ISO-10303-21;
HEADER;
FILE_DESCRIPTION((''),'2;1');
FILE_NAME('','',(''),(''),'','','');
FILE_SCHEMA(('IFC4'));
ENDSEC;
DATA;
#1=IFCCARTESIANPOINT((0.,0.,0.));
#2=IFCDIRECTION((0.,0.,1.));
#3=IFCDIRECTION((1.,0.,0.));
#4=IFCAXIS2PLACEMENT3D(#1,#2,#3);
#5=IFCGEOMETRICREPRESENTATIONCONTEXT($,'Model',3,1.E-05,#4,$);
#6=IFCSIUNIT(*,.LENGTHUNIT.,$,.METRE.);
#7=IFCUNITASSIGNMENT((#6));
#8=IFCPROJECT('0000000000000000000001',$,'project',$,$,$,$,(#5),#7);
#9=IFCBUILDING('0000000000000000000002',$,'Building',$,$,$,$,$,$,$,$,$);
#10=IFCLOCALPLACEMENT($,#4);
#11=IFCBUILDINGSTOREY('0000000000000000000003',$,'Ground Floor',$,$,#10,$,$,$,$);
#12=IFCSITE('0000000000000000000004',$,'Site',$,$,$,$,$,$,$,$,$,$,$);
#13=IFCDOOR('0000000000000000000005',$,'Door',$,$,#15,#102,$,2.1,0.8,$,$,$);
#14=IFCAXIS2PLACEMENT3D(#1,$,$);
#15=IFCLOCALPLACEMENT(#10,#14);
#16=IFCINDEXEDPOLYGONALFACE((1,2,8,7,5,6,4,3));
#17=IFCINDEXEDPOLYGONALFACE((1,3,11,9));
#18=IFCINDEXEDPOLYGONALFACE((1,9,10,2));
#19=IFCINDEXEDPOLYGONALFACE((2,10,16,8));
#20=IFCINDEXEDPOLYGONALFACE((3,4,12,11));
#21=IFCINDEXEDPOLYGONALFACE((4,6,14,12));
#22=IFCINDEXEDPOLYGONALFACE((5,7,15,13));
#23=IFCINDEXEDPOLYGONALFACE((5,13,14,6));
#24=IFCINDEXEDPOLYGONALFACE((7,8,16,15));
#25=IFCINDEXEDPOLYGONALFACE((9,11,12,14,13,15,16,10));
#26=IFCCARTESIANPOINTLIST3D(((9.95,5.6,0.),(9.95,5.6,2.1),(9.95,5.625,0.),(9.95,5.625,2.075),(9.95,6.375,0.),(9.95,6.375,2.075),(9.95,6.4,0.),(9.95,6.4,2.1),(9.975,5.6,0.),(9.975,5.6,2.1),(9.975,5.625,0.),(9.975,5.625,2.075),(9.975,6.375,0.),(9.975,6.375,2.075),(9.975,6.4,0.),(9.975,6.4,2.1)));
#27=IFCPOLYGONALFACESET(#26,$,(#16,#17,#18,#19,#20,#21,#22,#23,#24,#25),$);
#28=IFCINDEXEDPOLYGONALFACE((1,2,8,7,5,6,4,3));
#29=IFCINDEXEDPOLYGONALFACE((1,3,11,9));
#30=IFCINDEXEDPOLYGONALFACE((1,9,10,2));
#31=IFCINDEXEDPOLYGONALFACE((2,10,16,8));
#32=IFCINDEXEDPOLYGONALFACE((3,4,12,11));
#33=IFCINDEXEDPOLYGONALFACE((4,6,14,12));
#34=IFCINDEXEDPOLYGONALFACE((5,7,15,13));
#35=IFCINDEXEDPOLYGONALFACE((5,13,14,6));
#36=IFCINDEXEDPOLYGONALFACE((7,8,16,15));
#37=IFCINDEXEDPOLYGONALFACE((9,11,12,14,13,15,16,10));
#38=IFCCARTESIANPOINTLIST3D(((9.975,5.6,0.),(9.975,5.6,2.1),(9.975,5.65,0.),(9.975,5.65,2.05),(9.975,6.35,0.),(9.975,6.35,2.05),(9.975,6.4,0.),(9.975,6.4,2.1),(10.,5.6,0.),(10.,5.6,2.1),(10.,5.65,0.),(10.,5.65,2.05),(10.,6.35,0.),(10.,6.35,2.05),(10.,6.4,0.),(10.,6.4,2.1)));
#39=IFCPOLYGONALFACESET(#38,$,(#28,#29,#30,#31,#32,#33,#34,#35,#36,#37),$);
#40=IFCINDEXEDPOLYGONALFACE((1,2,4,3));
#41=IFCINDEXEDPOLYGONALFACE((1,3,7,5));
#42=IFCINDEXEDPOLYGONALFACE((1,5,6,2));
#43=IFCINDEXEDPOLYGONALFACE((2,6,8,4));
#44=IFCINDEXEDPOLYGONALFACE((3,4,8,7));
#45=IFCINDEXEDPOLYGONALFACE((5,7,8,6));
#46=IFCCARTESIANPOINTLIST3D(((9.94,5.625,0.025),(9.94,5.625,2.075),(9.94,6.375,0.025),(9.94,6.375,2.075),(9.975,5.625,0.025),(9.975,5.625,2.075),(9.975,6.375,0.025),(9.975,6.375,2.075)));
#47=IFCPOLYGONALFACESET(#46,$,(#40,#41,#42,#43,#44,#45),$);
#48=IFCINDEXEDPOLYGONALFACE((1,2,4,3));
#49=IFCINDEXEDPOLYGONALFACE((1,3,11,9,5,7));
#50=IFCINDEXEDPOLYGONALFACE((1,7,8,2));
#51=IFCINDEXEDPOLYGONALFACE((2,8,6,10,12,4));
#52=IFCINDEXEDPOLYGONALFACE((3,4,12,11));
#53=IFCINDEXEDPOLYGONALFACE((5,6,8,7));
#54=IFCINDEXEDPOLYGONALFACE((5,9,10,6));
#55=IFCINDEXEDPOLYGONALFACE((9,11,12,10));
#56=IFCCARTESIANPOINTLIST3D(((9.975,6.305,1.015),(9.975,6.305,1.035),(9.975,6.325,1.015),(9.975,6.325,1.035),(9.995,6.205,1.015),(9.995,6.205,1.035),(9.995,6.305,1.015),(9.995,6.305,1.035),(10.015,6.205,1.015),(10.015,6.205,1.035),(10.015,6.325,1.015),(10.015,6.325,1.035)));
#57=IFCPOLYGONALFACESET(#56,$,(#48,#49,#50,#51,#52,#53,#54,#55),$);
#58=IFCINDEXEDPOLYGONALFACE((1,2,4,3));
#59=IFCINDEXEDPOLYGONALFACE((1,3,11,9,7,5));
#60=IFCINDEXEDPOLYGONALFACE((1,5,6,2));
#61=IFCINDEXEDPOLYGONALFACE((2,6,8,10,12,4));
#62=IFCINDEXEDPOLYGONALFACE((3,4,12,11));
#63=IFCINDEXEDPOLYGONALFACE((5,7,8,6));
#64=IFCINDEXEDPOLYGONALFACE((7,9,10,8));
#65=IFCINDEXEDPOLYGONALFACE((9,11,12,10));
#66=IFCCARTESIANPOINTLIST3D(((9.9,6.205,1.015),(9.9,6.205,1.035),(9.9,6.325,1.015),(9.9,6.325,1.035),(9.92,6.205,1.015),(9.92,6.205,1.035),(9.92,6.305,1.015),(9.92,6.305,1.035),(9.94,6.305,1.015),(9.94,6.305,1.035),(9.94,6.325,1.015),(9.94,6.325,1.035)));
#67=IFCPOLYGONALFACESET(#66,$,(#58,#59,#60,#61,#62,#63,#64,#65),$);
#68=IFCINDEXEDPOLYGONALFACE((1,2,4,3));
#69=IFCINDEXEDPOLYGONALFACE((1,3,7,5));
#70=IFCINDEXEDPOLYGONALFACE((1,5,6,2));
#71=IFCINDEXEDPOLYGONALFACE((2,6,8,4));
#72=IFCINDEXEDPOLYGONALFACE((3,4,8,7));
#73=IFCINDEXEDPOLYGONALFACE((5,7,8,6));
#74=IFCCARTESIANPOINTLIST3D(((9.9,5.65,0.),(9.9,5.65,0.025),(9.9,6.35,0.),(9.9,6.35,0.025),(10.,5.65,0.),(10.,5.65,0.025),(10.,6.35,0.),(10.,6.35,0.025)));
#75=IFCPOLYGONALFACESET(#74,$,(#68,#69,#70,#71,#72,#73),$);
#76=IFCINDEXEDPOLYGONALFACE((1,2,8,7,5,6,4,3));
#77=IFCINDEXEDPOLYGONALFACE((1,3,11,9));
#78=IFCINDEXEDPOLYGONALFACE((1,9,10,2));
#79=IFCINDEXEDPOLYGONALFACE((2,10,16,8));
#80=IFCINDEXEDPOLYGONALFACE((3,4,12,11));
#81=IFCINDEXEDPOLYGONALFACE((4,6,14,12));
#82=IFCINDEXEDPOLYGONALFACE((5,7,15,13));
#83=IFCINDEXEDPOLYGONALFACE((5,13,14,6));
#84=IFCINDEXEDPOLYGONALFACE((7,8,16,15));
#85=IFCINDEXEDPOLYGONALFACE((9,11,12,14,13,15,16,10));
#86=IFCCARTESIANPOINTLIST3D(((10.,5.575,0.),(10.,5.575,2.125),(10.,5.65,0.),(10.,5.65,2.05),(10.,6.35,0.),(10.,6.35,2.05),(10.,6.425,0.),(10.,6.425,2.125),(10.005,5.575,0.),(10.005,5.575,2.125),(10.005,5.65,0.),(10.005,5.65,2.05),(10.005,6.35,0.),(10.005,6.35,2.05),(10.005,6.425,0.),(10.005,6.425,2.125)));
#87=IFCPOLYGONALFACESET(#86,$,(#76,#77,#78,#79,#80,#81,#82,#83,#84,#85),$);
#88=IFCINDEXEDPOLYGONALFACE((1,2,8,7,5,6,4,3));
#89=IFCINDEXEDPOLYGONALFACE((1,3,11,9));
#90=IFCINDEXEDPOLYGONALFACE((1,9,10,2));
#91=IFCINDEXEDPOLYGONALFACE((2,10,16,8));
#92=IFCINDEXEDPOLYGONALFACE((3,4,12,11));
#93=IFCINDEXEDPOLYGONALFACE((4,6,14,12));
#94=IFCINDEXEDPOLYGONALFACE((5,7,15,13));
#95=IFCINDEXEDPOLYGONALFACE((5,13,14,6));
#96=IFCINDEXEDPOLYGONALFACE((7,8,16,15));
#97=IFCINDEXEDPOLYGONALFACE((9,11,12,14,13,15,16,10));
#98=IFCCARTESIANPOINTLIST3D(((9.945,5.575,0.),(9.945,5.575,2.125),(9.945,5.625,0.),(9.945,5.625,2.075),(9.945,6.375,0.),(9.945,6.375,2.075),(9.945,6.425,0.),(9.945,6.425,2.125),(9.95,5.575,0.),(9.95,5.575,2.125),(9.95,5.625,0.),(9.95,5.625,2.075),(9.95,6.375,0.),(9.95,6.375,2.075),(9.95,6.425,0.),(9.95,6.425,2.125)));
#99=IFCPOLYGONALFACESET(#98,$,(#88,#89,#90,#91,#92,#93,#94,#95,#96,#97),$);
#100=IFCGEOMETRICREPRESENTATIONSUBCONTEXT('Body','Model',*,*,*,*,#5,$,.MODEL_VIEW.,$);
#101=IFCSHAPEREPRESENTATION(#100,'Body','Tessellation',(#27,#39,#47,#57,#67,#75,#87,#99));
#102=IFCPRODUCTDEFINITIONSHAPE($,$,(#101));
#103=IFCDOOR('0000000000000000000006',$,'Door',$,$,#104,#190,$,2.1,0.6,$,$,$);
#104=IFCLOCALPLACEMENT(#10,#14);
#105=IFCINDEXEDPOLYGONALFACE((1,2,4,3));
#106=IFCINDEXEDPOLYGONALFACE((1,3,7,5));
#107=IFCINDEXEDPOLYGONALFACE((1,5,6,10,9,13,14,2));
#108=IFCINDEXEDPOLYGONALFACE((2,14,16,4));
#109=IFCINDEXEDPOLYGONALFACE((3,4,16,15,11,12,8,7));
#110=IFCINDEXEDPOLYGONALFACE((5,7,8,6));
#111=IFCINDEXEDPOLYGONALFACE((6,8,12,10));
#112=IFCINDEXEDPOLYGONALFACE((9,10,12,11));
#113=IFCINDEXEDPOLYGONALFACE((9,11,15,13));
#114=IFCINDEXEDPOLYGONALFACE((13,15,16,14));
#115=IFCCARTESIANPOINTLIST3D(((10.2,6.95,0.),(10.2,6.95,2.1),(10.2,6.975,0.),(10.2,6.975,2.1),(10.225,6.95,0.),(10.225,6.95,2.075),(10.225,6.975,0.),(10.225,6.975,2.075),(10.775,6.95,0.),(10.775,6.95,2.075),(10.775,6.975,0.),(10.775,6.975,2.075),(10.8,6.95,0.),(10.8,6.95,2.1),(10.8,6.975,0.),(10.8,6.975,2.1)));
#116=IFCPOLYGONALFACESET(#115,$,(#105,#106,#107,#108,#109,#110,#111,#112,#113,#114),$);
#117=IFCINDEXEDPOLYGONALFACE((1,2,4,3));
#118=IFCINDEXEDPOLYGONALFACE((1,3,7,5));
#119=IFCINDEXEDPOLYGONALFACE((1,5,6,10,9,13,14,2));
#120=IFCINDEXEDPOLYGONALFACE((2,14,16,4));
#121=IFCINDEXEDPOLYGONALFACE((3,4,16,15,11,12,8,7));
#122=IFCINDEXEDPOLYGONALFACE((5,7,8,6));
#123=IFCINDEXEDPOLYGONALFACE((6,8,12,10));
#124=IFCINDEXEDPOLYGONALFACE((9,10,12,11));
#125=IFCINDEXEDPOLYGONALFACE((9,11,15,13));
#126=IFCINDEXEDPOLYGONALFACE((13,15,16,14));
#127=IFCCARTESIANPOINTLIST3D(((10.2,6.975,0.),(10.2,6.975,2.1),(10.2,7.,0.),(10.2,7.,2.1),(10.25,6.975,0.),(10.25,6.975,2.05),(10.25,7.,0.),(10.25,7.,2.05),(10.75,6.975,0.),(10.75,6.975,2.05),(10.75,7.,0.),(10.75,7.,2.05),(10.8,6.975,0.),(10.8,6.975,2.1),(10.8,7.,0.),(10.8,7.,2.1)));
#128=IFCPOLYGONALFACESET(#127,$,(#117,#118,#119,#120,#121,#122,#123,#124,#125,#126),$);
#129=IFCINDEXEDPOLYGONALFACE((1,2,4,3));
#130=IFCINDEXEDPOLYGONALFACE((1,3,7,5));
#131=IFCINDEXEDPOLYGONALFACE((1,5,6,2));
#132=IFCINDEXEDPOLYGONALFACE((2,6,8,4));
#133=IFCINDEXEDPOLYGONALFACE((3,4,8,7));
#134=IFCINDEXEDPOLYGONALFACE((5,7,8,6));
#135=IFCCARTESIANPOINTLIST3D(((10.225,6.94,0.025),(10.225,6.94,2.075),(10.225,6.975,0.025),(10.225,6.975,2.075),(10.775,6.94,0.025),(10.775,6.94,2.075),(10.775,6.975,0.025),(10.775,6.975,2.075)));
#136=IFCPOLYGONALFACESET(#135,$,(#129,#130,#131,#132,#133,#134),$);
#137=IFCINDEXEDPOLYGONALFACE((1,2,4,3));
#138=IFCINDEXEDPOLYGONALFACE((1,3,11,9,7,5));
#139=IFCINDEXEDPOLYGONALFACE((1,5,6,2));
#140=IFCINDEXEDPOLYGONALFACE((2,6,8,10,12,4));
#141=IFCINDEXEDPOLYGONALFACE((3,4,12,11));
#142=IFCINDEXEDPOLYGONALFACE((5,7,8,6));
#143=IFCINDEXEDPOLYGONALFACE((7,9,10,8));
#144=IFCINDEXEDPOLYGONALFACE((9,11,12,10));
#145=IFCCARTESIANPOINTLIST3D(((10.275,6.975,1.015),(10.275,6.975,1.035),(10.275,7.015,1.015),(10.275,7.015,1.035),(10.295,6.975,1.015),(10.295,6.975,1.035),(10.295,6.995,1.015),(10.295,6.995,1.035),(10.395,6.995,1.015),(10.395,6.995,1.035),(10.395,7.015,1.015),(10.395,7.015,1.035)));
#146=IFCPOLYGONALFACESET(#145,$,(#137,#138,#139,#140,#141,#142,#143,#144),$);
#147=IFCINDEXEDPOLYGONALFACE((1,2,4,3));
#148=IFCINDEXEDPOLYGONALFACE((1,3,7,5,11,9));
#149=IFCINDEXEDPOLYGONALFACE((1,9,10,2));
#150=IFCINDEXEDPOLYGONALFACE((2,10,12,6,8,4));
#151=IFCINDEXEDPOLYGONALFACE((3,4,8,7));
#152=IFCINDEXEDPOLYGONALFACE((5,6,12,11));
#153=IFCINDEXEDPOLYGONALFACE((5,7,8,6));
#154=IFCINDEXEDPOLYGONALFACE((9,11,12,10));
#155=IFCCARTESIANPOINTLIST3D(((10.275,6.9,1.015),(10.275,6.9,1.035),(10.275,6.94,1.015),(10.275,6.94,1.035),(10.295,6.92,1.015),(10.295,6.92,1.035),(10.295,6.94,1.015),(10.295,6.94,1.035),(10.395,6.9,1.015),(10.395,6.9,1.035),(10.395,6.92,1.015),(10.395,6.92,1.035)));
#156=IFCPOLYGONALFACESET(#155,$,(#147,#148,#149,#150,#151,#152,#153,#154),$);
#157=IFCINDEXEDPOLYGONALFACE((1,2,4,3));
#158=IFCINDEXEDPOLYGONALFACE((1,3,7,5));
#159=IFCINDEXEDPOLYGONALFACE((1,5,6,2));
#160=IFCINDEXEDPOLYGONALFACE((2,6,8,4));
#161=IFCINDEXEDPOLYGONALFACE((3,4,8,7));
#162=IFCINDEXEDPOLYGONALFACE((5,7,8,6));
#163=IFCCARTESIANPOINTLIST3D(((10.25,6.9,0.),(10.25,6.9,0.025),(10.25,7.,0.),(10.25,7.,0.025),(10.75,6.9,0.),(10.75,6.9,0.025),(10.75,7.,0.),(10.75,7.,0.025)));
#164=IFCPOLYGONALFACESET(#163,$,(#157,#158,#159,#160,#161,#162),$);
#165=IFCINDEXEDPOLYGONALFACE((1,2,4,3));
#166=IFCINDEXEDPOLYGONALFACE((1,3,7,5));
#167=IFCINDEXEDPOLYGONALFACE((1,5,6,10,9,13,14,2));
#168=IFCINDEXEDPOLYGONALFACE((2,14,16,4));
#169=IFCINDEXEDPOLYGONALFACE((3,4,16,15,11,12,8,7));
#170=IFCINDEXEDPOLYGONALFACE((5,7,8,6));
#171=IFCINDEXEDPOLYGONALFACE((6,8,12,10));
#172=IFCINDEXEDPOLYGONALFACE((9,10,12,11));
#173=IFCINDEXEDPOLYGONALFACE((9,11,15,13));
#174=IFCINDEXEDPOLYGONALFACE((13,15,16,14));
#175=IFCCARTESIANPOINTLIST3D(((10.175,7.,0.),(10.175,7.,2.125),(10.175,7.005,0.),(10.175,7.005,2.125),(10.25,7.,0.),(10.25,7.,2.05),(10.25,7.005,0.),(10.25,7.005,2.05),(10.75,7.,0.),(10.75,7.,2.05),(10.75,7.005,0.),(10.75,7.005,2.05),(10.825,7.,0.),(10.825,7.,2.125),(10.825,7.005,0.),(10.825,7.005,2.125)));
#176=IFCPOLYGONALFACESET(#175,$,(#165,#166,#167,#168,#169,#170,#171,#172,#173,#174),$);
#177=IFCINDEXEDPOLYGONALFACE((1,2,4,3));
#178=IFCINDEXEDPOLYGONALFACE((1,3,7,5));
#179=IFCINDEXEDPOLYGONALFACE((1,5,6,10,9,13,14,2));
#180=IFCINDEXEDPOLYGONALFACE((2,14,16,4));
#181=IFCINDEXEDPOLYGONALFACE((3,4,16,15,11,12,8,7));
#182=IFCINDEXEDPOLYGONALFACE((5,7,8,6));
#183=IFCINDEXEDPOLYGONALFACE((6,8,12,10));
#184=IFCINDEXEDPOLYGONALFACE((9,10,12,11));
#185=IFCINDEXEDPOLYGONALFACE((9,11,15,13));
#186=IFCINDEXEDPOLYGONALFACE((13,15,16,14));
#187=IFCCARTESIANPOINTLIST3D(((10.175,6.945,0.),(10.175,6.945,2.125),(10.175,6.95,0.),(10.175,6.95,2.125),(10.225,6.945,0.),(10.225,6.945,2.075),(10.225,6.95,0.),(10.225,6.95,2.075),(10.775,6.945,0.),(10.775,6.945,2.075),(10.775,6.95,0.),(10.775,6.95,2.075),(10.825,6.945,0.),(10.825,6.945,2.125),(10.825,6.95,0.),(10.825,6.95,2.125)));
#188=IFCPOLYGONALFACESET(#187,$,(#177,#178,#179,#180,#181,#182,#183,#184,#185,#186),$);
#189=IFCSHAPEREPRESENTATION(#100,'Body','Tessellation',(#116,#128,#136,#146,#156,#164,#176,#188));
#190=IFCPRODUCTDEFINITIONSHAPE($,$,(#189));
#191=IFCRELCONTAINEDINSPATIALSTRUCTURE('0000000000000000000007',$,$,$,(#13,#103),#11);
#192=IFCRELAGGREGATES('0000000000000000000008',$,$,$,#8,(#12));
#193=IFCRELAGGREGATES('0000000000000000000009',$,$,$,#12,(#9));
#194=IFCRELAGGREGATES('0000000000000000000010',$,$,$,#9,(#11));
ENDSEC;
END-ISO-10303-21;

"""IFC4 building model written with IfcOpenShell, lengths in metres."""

from ifc_helpers import new_model, si_unit, frame, origin_with_axes, place, context, subcontext, project, spatial, line, indexed_curve, outline, extrude, element, save


model = new_model("IFC4")

# Units and contexts
model_context = context("Model", 3, precision=1e-05, world=origin_with_axes())
body_context = subcontext(model_context, "Body", "Model", "MODEL_VIEW")
ifc_project = project(units=[si_unit("LENGTHUNIT", "METRE")], contexts=[model_context])

# Site, building, storey
site = spatial("IfcSite", under=ifc_project, Name="Site")
building = spatial("IfcBuilding", under=site, Name="Building")
storey_placement = place(None, origin_with_axes())
storey = spatial("IfcBuildingStorey", under=building, at=storey_placement, Name="Ground Floor")

# Doors
door_1_placement = place(storey_placement, frame((10.0, 5.6, 0.0), z_axis=(0.0, 0.0, 1.0), x_axis=(0.0, 1.0, 0.0)))
element("IfcDoor", 1, at=door_1_placement, inside=storey, Name="Door", OverallHeight=2.1, OverallWidth=0.8, context=body_context, shape_type="SweptSolid", body=[
    extrude(outline(indexed_curve([(0.0, 0.0), (0.0, 2.1), (0.8, 2.1), (0.8, 0.0), (0.775, 0.0), (0.775, 2.075), (0.025, 2.075), (0.025, 0.0)], segments=[line(1, 2, 3, 4, 5, 6, 7, 8, 1)])), frame((0.0, 0.025, 0.0), z_axis=(0.0, -1.0, 0.0), x_axis=(1.0, 0.0, 0.0)), (0.0, 0.0, -1.0), 0.025),
    extrude(outline(indexed_curve([(0.0, 0.0), (0.0, 2.1), (0.8, 2.1), (0.8, 0.0), (0.75, 0.0), (0.75, 2.05), (0.05, 2.05), (0.05, 0.0)], segments=[line(1, 2, 3, 4, 5, 6, 7, 8, 1)])), frame((0.0, 0.0, 0.0), z_axis=(0.0, -1.0, 0.0), x_axis=(1.0, 0.0, 0.0)), (0.0, 0.0, -1.0), 0.025),
    extrude(outline(indexed_curve([(0.0, 0.0), (0.75, 0.0), (0.75, 0.035), (0.0, 0.035)], segments=[line(1, 2, 3, 4, 1)])), frame((0.025, 0.025, 0.025), z_axis=(0.0, 0.0, 1.0), x_axis=(1.0, 0.0, 0.0)), (0.0, 0.0, 1.0), 2.05),
    extrude(outline(indexed_curve([(0.0, 0.0), (0.0, -0.04), (-0.12, -0.04), (-0.12, -0.02), (-0.02, -0.02), (-0.02, 0.0)], segments=[line(1, 2, 3, 4, 5, 6, 1)])), frame((0.725, 0.025, 1.015), z_axis=(0.0, 0.0, 1.0), x_axis=(1.0, 0.0, 0.0)), (0.0, 0.0, 1.0), 0.02),
    extrude(outline(indexed_curve([(0.0, 0.0), (0.0, 0.04), (-0.12, 0.04), (-0.12, 0.02), (-0.02, 0.02), (-0.02, 0.0)], segments=[line(1, 2, 3, 4, 5, 6, 1)])), frame((0.725, 0.06, 1.015), z_axis=(0.0, 0.0, 1.0), x_axis=(1.0, 0.0, 0.0)), (0.0, 0.0, 1.0), 0.02),
    extrude(outline(indexed_curve([(0.0, 0.0), (0.7, 0.0), (0.7, 0.1), (0.0, 0.1)], segments=[line(1, 2, 3, 4, 1)])), frame((0.05, 0.0, 0.0), z_axis=(0.0, 0.0, 1.0), x_axis=(1.0, 0.0, 0.0)), (0.0, 0.0, 1.0), 0.025),
    extrude(outline(indexed_curve([(0.0, 0.0), (0.0, 2.125), (0.85, 2.125), (0.85, 0.0), (0.775, 0.0), (0.775, 2.05), (0.075, 2.05), (0.075, 0.0)], segments=[line(1, 2, 3, 4, 5, 6, 7, 8, 1)])), frame((-0.025, -0.005, 0.0), z_axis=(0.0, -1.0, 0.0), x_axis=(1.0, 0.0, 0.0)), (0.0, 0.0, -1.0), 0.005),
    extrude(outline(indexed_curve([(0.0, 0.0), (0.0, 2.125), (0.85, 2.125), (0.85, 0.0), (0.8, 0.0), (0.8, 2.075), (0.05, 2.075), (0.05, 0.0)], segments=[line(1, 2, 3, 4, 5, 6, 7, 8, 1)])), frame((-0.025, 0.05, 0.0), z_axis=(0.0, -1.0, 0.0), x_axis=(1.0, 0.0, 0.0)), (0.0, 0.0, -1.0), 0.005),
])
door_2_placement = place(storey_placement, frame((10.8, 7.0, 0.0), z_axis=(0.0, 0.0, 1.0), x_axis=(-1.0, 0.0, 0.0)))
element("IfcDoor", 2, at=door_2_placement, inside=storey, Name="Door", OverallHeight=2.1, OverallWidth=0.6, context=body_context, shape_type="SweptSolid", body=[
    extrude(outline(indexed_curve([(0.0, 0.0), (0.0, 2.1), (0.6, 2.1), (0.6, 0.0), (0.575, 0.0), (0.575, 2.075), (0.025, 2.075), (0.025, 0.0)], segments=[line(1, 2, 3, 4, 5, 6, 7, 8, 1)])), frame((0.0, 0.025, 0.0), z_axis=(0.0, -1.0, 0.0), x_axis=(1.0, 0.0, 0.0)), (0.0, 0.0, -1.0), 0.025),
    extrude(outline(indexed_curve([(0.0, 0.0), (0.0, 2.1), (0.6, 2.1), (0.6, 0.0), (0.55, 0.0), (0.55, 2.05), (0.05, 2.05), (0.05, 0.0)], segments=[line(1, 2, 3, 4, 5, 6, 7, 8, 1)])), frame((0.0, 0.0, 0.0), z_axis=(0.0, -1.0, 0.0), x_axis=(1.0, 0.0, 0.0)), (0.0, 0.0, -1.0), 0.025),
    extrude(outline(indexed_curve([(0.0, 0.0), (0.55, 0.0), (0.55, 0.035), (0.0, 0.035)], segments=[line(1, 2, 3, 4, 1)])), frame((0.025, 0.025, 0.025), z_axis=(0.0, 0.0, 1.0), x_axis=(1.0, 0.0, 0.0)), (0.0, 0.0, 1.0), 2.05),
    extrude(outline(indexed_curve([(0.0, 0.0), (0.0, -0.04), (-0.12, -0.04), (-0.12, -0.02), (-0.02, -0.02), (-0.02, 0.0)], segments=[line(1, 2, 3, 4, 5, 6, 1)])), frame((0.525, 0.025, 1.015), z_axis=(0.0, 0.0, 1.0), x_axis=(1.0, 0.0, 0.0)), (0.0, 0.0, 1.0), 0.02),
    extrude(outline(indexed_curve([(0.0, 0.0), (0.0, 0.04), (-0.12, 0.04), (-0.12, 0.02), (-0.02, 0.02), (-0.02, 0.0)], segments=[line(1, 2, 3, 4, 5, 6, 1)])), frame((0.525, 0.06, 1.015), z_axis=(0.0, 0.0, 1.0), x_axis=(1.0, 0.0, 0.0)), (0.0, 0.0, 1.0), 0.02),
    extrude(outline(indexed_curve([(0.0, 0.0), (0.5, 0.0), (0.5, 0.1), (0.0, 0.1)], segments=[line(1, 2, 3, 4, 1)])), frame((0.05, 0.0, 0.0), z_axis=(0.0, 0.0, 1.0), x_axis=(1.0, 0.0, 0.0)), (0.0, 0.0, 1.0), 0.025),
    extrude(outline(indexed_curve([(0.0, 0.0), (0.0, 2.125), (0.65, 2.125), (0.65, 0.0), (0.575, 0.0), (0.575, 2.05), (0.075, 2.05), (0.075, 0.0)], segments=[line(1, 2, 3, 4, 5, 6, 7, 8, 1)])), frame((-0.025, -0.005, 0.0), z_axis=(0.0, -1.0, 0.0), x_axis=(1.0, 0.0, 0.0)), (0.0, 0.0, -1.0), 0.005),
    extrude(outline(indexed_curve([(0.0, 0.0), (0.0, 2.125), (0.65, 2.125), (0.65, 0.0), (0.6, 0.0), (0.6, 2.075), (0.05, 2.075), (0.05, 0.0)], segments=[line(1, 2, 3, 4, 5, 6, 7, 8, 1)])), frame((-0.025, 0.05, 0.0), z_axis=(0.0, -1.0, 0.0), x_axis=(1.0, 0.0, 0.0)), (0.0, 0.0, -1.0), 0.005),
])

save(model, "model.ifc")
